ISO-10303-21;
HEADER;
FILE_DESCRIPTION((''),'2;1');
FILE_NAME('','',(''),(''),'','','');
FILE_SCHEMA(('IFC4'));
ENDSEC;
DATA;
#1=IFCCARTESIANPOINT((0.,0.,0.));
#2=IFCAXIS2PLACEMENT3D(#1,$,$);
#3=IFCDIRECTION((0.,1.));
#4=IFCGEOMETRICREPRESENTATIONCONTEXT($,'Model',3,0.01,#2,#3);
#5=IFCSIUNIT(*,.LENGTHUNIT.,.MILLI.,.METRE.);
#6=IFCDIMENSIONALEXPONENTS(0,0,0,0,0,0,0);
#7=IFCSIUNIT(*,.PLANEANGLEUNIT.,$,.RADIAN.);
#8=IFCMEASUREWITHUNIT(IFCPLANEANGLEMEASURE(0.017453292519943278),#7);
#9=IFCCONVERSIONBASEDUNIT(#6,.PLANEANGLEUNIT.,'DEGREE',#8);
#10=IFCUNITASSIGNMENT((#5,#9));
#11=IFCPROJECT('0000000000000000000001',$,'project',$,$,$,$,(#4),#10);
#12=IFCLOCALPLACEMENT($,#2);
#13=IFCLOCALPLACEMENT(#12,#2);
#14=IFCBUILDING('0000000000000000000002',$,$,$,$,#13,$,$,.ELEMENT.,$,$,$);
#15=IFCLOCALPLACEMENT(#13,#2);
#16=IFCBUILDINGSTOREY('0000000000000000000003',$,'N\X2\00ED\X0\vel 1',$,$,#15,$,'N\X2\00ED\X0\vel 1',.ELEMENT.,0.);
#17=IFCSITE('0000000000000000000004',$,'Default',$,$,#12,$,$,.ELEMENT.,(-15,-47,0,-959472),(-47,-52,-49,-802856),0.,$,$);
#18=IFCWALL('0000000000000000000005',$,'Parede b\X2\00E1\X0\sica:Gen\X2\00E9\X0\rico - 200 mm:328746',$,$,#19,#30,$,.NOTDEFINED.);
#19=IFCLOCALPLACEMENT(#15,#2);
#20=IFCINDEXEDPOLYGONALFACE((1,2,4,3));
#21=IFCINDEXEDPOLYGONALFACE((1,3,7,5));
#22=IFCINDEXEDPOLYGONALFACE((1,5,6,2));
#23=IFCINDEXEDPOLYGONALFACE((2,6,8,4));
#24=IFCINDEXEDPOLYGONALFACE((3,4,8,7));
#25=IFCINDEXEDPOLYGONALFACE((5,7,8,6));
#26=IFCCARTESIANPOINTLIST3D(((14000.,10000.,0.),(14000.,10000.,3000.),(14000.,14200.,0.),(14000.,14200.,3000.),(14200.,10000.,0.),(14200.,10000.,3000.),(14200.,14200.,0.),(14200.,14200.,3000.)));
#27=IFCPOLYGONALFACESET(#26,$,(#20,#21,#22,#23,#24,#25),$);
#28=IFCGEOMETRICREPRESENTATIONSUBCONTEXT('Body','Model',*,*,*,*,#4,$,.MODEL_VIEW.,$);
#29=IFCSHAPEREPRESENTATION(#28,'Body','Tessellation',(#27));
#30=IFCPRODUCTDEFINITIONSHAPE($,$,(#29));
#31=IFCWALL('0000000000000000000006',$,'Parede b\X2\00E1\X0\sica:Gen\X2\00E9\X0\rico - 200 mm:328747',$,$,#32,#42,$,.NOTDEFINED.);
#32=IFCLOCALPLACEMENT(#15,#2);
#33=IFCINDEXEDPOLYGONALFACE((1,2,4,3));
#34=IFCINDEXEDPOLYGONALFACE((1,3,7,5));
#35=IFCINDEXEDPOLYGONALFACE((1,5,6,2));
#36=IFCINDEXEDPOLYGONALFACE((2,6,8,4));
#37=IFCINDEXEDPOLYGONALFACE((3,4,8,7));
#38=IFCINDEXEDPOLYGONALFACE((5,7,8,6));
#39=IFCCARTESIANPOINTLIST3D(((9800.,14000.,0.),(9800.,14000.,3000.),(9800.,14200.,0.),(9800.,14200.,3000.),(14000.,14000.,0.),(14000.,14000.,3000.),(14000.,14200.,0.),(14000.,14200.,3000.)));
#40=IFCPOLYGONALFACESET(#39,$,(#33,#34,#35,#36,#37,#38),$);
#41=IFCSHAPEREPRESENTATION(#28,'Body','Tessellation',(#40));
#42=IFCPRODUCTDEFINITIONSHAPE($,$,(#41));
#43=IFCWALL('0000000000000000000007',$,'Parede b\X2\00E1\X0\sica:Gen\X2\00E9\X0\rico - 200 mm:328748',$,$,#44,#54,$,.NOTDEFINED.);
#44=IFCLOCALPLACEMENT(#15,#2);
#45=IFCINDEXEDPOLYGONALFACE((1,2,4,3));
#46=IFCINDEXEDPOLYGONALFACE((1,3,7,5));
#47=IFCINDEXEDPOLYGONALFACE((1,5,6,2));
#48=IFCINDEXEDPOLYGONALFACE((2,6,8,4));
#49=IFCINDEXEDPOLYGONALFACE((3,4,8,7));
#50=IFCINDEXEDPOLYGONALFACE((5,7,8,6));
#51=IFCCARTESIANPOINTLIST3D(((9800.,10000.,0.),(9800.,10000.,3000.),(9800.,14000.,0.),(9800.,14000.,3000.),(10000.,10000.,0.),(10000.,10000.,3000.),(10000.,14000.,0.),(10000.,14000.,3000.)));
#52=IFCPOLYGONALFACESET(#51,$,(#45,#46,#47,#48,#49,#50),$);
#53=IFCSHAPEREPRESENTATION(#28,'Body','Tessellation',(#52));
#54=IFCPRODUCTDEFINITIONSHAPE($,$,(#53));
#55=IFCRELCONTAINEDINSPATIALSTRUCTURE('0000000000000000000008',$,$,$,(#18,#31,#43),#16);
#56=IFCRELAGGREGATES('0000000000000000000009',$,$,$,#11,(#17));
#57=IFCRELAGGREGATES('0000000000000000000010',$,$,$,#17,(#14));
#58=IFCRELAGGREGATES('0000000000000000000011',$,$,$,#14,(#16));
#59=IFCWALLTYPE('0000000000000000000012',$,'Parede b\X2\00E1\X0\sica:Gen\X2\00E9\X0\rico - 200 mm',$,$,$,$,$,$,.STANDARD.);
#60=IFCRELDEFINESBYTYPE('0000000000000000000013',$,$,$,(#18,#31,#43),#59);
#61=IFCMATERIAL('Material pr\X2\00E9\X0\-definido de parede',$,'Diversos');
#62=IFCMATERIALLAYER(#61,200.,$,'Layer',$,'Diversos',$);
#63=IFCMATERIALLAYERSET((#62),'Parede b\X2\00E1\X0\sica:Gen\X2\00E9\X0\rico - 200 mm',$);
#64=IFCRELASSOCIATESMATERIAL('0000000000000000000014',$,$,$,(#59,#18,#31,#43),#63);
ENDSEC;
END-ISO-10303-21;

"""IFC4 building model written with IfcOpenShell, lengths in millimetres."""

from ifc_helpers import new_model, entity, si_unit, converted_unit, direction, frame, frame_2d, origin, place, context, subcontext, project, spatial, rectangle, extrude, material, layer, layer_set, layer_usage, type_object, element, save


model = new_model("IFC4")

# Units and contexts
model_context = context("Model", 3, precision=0.01, world=origin(), true_north=direction((0.0, 1.0)))
body_context = subcontext(model_context, "Body", "Model", "MODEL_VIEW")
ifc_project = project(units=[si_unit("LENGTHUNIT", "METRE", prefix="MILLI"), converted_unit("PLANEANGLEUNIT", "DEGREE", entity("IfcPlaneAngleMeasure", 0.017453292519943278), si_unit("PLANEANGLEUNIT", "RADIAN"), dimensions=[0, 0, 0, 0, 0, 0, 0])], contexts=[model_context])

# Site, building, storey
site_placement = place(None, origin())
site = spatial("IfcSite", under=ifc_project, at=site_placement, Name="Default", CompositionType="ELEMENT", RefLatitude=(-15, -47, 0, -959472), RefLongitude=(-47, -52, -49, -802856), RefElevation=0.0)
building_placement = place(site_placement, origin())
building = spatial("IfcBuilding", under=site, at=building_placement, CompositionType="ELEMENT")
storey_placement = place(building_placement, origin())
storey = spatial("IfcBuildingStorey", under=building, at=storey_placement, Name="Nível 1", LongName="Nível 1", CompositionType="ELEMENT", Elevation=0.0)

# Shared definitions
ifc_material_1 = material(Name="Material pré-definido de parede", Category="Diversos")
ifc_layer_1 = layer(ifc_material_1, 200.0, Name="Layer", Category="Diversos")
ifc_layer_set_1 = layer_set([ifc_layer_1], Name="Parede básica:Genérico - 200 mm")
wall_type = type_object("IfcWallType", Name="Parede básica:Genérico - 200 mm", PredefinedType="STANDARD", material=ifc_layer_set_1)

# Walls
ifc_layer_usage_1 = layer_usage(ifc_layer_set_1, "AXIS2", "NEGATIVE", 100.0)
wall_1_placement = place(storey_placement, frame((14100.0, 10000.0, 0.0), z_axis=(0.0, 0.0, 1.0), x_axis=(0.0, 1.0, 0.0)))
element("IfcWall", 1, at=wall_1_placement, inside=storey, type_object=wall_type, material=ifc_layer_usage_1, Name="Parede básica:Genérico - 200 mm:328746", PredefinedType="NOTDEFINED", context=body_context, shape_type="SweptSolid", body=[
    extrude(rectangle(XDim=4200.0, YDim=200.0, at=frame_2d((2100.0, 0.0), x_axis=(-1.0, 0.0))), origin(), (0.0, 0.0, 1.0), 3000.0),
])
ifc_layer_usage_2 = layer_usage(ifc_layer_set_1, "AXIS2", "NEGATIVE", 100.0)
wall_2_placement = place(storey_placement, frame((14000.0, 14100.0, 0.0), z_axis=(0.0, 0.0, 1.0), x_axis=(-1.0, 0.0, 0.0)))
element("IfcWall", 2, at=wall_2_placement, inside=storey, type_object=wall_type, material=ifc_layer_usage_2, Name="Parede básica:Genérico - 200 mm:328747", PredefinedType="NOTDEFINED", context=body_context, shape_type="SweptSolid", body=[
    extrude(rectangle(XDim=4200.0, YDim=200.0, at=frame_2d((2100.0, 0.0), x_axis=(-1.0, 0.0))), origin(), (0.0, 0.0, 1.0), 3000.0),
])
ifc_layer_usage_3 = layer_usage(ifc_layer_set_1, "AXIS2", "NEGATIVE", 100.0)
wall_3_placement = place(storey_placement, frame((9900.0, 14000.0, 0.0), z_axis=(0.0, 0.0, 1.0), x_axis=(0.0, -1.0, 0.0)))
element("IfcWall", 3, at=wall_3_placement, inside=storey, type_object=wall_type, material=ifc_layer_usage_3, Name="Parede básica:Genérico - 200 mm:328748", PredefinedType="NOTDEFINED", context=body_context, shape_type="SweptSolid", body=[
    extrude(rectangle(XDim=4000.0, YDim=200.0, at=frame_2d((2000.0, 0.0), x_axis=(-1.0, 0.0))), origin(), (0.0, 0.0, 1.0), 3000.0),
])

save(model, "model.ifc")
